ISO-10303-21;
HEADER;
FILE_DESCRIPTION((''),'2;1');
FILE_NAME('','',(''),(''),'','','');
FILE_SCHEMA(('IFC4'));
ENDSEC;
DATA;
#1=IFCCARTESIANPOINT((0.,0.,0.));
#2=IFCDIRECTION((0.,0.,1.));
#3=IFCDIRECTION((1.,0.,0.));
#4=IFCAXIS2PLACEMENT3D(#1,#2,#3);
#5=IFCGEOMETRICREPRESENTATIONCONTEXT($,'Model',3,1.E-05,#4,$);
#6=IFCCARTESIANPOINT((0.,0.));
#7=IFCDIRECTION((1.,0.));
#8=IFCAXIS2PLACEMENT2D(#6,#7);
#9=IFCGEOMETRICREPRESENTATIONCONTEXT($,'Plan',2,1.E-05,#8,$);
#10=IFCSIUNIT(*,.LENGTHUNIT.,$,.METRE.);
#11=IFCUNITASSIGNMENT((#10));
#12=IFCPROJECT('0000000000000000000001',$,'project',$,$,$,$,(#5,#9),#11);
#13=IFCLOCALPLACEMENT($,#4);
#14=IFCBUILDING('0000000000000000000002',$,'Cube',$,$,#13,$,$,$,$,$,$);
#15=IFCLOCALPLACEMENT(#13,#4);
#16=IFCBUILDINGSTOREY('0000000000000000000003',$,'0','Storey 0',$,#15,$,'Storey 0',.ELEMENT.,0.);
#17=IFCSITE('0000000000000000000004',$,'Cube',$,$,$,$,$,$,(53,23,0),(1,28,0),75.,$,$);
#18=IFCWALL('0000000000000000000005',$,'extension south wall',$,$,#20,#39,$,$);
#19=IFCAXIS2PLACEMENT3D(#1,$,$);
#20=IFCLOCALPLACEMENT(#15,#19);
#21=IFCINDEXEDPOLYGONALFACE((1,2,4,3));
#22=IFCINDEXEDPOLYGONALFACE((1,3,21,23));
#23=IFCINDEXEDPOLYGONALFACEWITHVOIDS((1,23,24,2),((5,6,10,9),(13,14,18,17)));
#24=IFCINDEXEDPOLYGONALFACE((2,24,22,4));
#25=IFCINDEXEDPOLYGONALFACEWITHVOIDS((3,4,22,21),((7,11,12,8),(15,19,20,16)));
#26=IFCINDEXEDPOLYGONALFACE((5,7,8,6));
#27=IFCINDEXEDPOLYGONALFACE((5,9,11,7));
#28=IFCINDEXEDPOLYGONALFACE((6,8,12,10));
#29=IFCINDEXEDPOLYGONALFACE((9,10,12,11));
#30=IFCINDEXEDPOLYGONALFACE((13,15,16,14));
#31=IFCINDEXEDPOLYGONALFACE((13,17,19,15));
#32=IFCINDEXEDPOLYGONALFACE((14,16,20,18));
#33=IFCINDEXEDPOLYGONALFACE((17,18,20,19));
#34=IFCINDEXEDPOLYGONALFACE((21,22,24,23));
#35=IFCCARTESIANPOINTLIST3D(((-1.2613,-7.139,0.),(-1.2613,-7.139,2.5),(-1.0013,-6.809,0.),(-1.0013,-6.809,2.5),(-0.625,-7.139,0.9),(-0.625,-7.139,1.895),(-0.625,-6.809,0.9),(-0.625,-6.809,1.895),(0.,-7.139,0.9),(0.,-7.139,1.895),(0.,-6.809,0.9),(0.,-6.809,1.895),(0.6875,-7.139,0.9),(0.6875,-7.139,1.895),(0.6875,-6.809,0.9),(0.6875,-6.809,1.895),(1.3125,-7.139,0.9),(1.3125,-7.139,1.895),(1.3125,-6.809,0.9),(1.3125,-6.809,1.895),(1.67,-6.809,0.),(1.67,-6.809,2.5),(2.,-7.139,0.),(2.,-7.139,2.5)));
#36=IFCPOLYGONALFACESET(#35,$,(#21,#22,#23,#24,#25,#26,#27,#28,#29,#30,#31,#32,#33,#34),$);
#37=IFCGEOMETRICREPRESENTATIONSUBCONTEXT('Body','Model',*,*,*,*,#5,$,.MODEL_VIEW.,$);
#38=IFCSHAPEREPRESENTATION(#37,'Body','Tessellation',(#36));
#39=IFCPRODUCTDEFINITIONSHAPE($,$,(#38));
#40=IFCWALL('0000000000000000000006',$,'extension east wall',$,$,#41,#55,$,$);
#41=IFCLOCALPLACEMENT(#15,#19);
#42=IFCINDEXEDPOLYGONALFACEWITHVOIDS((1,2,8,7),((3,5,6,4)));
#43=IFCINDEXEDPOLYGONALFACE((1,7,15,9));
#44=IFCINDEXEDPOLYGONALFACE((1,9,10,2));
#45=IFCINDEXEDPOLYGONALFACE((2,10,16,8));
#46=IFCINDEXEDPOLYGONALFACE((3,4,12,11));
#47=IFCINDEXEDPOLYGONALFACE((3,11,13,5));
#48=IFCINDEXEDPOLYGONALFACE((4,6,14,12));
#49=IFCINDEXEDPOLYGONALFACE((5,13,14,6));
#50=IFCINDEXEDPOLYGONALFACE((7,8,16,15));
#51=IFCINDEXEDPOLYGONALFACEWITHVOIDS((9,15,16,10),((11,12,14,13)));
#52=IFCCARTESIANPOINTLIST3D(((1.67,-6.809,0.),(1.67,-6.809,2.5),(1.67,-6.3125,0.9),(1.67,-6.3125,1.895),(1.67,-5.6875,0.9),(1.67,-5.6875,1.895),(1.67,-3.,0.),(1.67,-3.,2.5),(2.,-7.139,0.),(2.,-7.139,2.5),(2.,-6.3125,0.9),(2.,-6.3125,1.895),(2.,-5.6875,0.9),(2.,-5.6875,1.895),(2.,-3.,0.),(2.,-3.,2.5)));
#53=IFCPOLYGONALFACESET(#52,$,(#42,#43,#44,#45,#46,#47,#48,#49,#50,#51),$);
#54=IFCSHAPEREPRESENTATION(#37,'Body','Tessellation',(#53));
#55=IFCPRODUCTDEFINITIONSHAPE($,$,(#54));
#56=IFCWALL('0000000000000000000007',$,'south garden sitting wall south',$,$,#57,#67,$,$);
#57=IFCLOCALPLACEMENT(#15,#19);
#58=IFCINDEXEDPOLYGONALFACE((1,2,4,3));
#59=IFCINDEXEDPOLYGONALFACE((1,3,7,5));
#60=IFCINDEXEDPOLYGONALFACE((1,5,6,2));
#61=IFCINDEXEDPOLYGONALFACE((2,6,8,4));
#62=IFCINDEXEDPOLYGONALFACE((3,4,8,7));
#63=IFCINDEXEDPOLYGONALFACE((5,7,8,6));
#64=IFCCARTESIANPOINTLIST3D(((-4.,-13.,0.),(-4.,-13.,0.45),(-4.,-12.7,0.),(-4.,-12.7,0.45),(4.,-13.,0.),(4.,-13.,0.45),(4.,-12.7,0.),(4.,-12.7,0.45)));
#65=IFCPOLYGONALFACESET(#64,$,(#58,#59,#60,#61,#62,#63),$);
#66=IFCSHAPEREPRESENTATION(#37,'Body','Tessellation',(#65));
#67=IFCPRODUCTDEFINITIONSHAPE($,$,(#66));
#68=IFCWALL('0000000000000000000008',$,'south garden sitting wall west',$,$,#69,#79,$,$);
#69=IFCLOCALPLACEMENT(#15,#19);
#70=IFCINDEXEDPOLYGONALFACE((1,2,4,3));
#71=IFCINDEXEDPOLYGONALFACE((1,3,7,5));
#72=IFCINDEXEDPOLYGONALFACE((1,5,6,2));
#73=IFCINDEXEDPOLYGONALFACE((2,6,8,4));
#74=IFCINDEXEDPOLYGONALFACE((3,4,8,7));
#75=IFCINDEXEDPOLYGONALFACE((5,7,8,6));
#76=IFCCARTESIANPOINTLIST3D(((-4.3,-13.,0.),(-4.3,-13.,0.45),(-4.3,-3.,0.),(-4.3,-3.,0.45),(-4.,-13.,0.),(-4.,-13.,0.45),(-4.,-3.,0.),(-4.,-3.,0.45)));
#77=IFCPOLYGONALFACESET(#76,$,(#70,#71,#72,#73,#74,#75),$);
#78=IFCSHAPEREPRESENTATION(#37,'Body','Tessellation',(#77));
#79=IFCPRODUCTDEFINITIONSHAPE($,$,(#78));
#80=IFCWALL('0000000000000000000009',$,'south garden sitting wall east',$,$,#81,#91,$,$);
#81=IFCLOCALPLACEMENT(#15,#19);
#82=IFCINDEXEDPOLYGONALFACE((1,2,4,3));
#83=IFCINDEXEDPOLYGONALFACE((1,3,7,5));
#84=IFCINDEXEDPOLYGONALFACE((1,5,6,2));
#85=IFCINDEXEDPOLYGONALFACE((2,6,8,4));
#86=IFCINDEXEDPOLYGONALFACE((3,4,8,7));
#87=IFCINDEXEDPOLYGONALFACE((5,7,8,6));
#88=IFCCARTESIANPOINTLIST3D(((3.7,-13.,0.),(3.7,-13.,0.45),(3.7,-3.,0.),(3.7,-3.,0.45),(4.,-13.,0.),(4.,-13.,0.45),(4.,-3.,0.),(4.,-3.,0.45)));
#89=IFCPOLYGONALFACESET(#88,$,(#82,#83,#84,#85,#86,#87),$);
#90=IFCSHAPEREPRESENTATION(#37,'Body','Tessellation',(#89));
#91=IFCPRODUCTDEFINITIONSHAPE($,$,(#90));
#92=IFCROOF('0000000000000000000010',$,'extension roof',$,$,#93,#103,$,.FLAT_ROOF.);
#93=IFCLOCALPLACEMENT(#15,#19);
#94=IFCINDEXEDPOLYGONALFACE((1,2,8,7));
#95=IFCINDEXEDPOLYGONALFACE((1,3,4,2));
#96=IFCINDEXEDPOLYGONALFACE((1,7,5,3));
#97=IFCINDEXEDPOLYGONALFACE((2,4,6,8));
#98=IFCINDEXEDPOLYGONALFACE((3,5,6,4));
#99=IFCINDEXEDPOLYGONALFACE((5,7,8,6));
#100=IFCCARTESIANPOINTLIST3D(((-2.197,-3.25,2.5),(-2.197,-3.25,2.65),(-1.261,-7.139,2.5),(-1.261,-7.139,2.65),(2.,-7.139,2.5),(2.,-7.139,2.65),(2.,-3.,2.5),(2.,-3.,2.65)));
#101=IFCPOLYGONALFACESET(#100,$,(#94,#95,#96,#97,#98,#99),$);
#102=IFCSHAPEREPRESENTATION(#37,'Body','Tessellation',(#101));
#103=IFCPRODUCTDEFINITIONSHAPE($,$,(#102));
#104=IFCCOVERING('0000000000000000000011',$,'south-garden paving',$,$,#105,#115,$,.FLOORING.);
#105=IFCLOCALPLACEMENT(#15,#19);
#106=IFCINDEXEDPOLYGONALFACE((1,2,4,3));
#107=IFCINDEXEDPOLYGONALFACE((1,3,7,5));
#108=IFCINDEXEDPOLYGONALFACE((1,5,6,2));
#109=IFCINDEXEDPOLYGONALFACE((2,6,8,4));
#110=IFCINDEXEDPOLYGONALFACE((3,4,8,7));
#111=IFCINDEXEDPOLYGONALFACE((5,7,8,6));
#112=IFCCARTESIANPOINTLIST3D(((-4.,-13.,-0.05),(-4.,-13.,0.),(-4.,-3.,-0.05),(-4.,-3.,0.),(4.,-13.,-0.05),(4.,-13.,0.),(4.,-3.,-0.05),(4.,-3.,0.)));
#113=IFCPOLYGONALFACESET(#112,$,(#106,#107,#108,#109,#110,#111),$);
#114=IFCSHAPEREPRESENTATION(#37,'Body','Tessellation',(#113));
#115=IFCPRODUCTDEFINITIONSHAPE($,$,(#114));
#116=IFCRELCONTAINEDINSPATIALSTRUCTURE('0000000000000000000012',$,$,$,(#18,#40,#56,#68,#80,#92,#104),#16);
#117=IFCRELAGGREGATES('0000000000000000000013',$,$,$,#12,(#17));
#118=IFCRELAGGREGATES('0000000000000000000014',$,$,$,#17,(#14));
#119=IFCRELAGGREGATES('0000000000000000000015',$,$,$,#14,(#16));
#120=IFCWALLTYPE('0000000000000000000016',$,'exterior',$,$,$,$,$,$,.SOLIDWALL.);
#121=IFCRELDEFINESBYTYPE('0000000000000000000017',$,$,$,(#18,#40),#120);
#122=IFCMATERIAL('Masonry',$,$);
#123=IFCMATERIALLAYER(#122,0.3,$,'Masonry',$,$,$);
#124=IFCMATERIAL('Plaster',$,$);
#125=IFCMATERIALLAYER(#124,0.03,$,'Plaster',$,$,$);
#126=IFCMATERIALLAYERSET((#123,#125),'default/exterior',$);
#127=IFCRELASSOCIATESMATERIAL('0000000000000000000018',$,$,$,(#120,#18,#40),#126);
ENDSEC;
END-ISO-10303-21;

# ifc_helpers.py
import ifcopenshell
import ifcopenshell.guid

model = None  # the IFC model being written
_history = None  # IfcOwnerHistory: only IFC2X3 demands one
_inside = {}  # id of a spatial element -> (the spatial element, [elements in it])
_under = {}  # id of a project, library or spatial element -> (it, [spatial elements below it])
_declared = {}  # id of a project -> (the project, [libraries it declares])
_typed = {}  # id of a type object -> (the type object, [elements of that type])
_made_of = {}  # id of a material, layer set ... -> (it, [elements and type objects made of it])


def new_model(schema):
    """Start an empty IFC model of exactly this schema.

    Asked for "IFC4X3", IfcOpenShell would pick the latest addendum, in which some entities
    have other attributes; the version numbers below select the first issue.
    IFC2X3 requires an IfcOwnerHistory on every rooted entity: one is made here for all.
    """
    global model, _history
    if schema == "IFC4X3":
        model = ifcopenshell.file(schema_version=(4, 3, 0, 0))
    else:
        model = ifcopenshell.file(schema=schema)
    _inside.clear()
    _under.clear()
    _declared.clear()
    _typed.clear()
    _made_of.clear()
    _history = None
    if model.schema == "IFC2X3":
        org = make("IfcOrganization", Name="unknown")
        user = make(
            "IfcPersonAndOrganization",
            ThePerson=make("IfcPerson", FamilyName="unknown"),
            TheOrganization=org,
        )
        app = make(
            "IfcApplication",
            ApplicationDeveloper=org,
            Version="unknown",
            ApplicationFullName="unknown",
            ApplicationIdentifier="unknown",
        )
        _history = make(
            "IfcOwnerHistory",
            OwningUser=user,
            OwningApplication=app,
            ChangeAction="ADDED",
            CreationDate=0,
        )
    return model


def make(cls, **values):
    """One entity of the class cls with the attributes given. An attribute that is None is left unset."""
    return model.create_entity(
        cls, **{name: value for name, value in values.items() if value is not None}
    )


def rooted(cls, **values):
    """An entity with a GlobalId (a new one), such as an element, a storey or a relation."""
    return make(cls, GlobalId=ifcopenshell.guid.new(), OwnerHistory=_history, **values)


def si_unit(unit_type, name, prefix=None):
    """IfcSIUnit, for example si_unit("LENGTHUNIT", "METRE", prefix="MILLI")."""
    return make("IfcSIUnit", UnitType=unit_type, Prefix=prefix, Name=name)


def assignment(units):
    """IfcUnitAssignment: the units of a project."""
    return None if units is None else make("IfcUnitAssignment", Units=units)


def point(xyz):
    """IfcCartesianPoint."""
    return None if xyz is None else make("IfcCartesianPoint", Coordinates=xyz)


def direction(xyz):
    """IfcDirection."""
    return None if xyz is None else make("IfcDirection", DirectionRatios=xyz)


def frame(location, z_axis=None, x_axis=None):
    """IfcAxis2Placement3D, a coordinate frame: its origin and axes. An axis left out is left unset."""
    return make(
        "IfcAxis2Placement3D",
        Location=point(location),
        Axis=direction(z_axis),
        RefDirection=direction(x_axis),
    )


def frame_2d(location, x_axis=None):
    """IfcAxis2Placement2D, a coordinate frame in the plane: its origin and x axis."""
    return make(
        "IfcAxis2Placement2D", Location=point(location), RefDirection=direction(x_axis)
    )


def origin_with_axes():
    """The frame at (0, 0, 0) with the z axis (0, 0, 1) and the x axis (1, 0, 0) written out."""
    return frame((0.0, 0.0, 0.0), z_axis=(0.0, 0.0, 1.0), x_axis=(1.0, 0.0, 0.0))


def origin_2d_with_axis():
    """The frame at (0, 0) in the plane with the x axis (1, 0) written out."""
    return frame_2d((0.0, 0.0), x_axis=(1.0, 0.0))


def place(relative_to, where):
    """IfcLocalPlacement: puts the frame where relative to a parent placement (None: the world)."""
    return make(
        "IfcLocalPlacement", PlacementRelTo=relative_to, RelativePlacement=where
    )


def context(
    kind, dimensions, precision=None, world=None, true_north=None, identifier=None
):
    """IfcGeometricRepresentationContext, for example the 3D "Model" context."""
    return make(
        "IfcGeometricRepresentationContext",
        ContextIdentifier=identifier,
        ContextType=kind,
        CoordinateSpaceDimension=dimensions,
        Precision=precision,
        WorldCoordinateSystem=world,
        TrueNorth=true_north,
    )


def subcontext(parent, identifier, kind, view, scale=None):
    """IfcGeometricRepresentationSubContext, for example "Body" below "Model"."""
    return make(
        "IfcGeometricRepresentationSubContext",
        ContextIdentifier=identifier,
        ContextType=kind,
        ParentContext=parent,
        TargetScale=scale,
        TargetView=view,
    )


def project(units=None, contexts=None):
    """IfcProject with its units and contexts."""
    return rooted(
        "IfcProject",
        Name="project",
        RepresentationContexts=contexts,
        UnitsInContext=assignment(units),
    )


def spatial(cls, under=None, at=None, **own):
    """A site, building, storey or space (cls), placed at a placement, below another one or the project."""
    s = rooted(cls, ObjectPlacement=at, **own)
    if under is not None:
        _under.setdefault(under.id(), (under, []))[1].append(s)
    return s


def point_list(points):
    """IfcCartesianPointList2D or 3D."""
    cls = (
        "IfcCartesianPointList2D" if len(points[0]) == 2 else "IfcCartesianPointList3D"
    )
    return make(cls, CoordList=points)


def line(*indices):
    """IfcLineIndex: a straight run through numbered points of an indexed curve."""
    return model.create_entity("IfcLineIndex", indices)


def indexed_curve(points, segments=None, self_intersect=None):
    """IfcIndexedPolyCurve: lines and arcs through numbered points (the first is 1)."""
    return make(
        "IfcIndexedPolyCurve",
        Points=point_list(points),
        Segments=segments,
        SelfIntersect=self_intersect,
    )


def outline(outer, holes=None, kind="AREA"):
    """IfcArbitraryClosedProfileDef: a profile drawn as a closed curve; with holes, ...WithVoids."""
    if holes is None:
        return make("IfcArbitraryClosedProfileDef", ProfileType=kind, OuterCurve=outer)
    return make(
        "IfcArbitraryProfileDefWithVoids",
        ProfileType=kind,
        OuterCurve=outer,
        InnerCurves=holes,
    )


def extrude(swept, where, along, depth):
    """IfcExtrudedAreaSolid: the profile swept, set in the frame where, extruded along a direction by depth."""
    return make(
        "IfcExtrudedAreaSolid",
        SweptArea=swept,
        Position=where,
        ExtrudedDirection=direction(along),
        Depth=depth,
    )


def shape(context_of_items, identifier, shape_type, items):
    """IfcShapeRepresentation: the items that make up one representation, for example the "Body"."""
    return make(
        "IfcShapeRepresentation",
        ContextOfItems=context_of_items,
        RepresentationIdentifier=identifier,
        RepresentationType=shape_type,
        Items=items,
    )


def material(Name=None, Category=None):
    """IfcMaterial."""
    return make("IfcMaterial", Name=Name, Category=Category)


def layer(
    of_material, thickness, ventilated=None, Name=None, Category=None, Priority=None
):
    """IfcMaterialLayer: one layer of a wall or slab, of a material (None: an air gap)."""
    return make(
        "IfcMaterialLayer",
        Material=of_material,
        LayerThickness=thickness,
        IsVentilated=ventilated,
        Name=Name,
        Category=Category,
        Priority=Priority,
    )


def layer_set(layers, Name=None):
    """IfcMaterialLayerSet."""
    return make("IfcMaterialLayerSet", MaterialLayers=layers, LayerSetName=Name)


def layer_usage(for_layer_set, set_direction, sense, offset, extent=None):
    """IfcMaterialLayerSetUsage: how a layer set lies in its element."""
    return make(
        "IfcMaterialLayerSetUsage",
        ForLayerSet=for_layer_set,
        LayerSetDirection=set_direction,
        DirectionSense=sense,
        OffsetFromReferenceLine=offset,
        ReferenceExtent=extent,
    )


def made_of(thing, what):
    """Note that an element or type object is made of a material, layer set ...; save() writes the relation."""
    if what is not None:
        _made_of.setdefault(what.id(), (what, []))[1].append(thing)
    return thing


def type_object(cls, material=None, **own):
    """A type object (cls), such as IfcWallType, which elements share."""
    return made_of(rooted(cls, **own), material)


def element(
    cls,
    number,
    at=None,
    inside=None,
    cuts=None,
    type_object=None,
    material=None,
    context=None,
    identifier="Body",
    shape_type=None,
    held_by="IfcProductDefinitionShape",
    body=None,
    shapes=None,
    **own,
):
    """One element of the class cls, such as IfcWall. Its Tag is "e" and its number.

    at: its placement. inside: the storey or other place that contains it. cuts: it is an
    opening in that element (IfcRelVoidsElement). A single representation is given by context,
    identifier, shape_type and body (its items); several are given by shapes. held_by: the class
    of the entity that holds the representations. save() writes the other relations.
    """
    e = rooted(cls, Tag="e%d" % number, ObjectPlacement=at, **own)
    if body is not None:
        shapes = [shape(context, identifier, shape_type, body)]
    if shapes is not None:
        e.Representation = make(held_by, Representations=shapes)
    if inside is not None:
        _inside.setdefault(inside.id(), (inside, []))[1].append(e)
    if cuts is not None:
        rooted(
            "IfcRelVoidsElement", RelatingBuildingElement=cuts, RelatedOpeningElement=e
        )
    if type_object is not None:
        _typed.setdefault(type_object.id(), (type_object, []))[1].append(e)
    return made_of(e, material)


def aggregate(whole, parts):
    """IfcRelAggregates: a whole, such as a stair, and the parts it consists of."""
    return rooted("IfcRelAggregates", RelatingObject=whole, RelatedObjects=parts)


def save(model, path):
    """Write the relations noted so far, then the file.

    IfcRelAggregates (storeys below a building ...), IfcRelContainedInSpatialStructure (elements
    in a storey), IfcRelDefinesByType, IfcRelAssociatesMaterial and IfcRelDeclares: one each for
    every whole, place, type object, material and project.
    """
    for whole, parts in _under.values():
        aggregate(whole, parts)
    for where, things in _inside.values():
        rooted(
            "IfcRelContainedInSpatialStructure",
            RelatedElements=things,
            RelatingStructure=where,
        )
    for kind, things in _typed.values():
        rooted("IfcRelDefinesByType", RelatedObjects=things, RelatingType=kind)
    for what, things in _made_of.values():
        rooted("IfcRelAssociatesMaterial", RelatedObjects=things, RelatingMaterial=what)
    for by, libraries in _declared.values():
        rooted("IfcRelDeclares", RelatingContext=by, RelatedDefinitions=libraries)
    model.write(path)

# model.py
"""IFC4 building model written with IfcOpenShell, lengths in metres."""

from ifc_helpers import new_model, si_unit, frame, origin_with_axes, origin_2d_with_axis, place, context, subcontext, project, spatial, line, indexed_curve, outline, extrude, material, layer, layer_set, layer_usage, type_object, element, save


model = new_model("IFC4")

# Units and contexts
model_context = context("Model", 3, precision=1e-05, world=origin_with_axes())
plan_context = context("Plan", 2, precision=1e-05, world=origin_2d_with_axis())
body_context_1 = subcontext(model_context, "Body", "Model", "MODEL_VIEW")
ifc_project = project(units=[si_unit("LENGTHUNIT", "METRE")], contexts=[model_context, plan_context])

# Site, building, storey
site = spatial("IfcSite", under=ifc_project, Name="Cube", RefLatitude=(53, 23, 0), RefLongitude=(1, 28, 0), RefElevation=75.0)
building_placement = place(None, origin_with_axes())
building = spatial("IfcBuilding", under=site, at=building_placement, Name="Cube")
storey_placement = place(building_placement, origin_with_axes())
storey = spatial("IfcBuildingStorey", under=building, at=storey_placement, Name="0", Description="Storey 0", LongName="Storey 0", CompositionType="ELEMENT", Elevation=0.0)

# Wall, openings
ifc_material_1 = material(Name="Masonry")
ifc_layer_1 = layer(ifc_material_1, 0.3, Name="Masonry")
ifc_material_2 = material(Name="Plaster")
ifc_layer_2 = layer(ifc_material_2, 0.03, Name="Plaster")
ifc_layer_set = layer_set([ifc_layer_1, ifc_layer_2], Name="default/exterior")
ifc_layer_usage = layer_usage(ifc_layer_set, "AXIS2", "POSITIVE", 0.0)
wall_type = type_object("IfcWallType", Name="exterior", PredefinedType="SOLIDWALL", material=ifc_layer_set)
wall_1_placement = place(storey_placement, frame((-1.2613, -7.139, 0.0), z_axis=(0.0, 0.0, 1.0), x_axis=(1.0, 0.0, 0.0)))
wall_1 = element("IfcWall", 1, at=wall_1_placement, inside=storey, type_object=wall_type, material=ifc_layer_usage, Name="extension south wall", context=body_context_1, shape_type="SweptSolid", body=[
    extrude(outline(indexed_curve([(0.0, 0.0), (0.26, 0.33), (2.9313, 0.33), (3.2613, 0.0)], segments=[line(1, 2, 3, 4, 1)])), origin_with_axes(), (0.0, 0.0, 1.0), 2.5),
])
opening_1_placement = place(wall_1_placement, frame((0.6363, 0.0, 0.9), z_axis=(0.0, 0.0, 1.0), x_axis=(1.0, 0.0, 0.0)))
element("IfcOpeningElement", 2, at=opening_1_placement, cuts=wall_1, PredefinedType="OPENING", context=body_context_1, shape_type="SweptSolid", body=[
    extrude(outline(indexed_curve([(0.0, 0.0), (0.0, 0.5), (0.625, 0.5), (0.625, 0.0), (0.0, 0.0)], self_intersect=False)), origin_with_axes(), (0.0, 0.0, 1.0), 0.995),
])
opening_2_placement = place(wall_1_placement, frame((1.9488, 0.0, 0.9), z_axis=(0.0, 0.0, 1.0), x_axis=(1.0, 0.0, 0.0)))
element("IfcOpeningElement", 3, at=opening_2_placement, cuts=wall_1, PredefinedType="OPENING", context=body_context_1, shape_type="SweptSolid", body=[
    extrude(outline(indexed_curve([(0.0, 0.0), (0.0, 0.5), (0.625, 0.5), (0.625, 0.0), (0.0, 0.0)], self_intersect=False)), origin_with_axes(), (0.0, 0.0, 1.0), 0.995),
])

# Wall, opening
wall_2_placement = place(storey_placement, frame((2.0, -7.139, 0.0), z_axis=(0.0, 0.0, 1.0), x_axis=(0.0, 1.0, 0.0)))
wall_2 = element("IfcWall", 4, at=wall_2_placement, inside=storey, type_object=wall_type, material=ifc_layer_usage, Name="extension east wall", context=body_context_1, shape_type="SweptSolid", body=[
    extrude(outline(indexed_curve([(0.0, 0.0), (0.33, 0.33), (4.139, 0.33), (4.139, 0.0)], segments=[line(1, 2, 3, 4, 1)])), origin_with_axes(), (0.0, 0.0, 1.0), 2.5),
])
opening_3_placement = place(wall_2_placement, frame((0.8265, 0.0, 0.9), z_axis=(0.0, 0.0, 1.0), x_axis=(1.0, 0.0, 0.0)))
element("IfcOpeningElement", 5, at=opening_3_placement, cuts=wall_2, PredefinedType="OPENING", context=body_context_1, shape_type="SweptSolid", body=[
    extrude(outline(indexed_curve([(0.0, 0.0), (0.0, 0.5), (0.625, 0.5), (0.625, 0.0), (0.0, 0.0)], self_intersect=False)), origin_with_axes(), (0.0, 0.0, 1.0), 0.995),
])

# Walls
wall_3_placement = place(storey_placement, frame((-4.0, -13.0, 0.0), z_axis=(0.0, 0.0, 1.0), x_axis=(1.0, 0.0, 0.0)))
element("IfcWall", 6, at=wall_3_placement, inside=storey, Name="south garden sitting wall south", context=body_context_1, shape_type="SweptSolid", body=[
    extrude(outline(indexed_curve([(0.0, 0.0), (0.0, 0.3), (8.0, 0.3), (8.0, 0.0), (0.0, 0.0)], self_intersect=False)), origin_with_axes(), (0.0, 0.0, 1.0), 0.45),
])
for number, where, z_axis, x_axis, name in (
    (7, (-4.0, -13.0, 0.0), (0.0, 0.0, 1.0), (0.0, 1.0, 0.0), "south garden sitting wall west"),
    (8, (4.0, -13.0, 0.0), (0.0, 0.0, 1.0), (0.0, 1.0, 0.0), "south garden sitting wall east"),
):
    element("IfcWall", number, at=place(storey_placement, frame(where, z_axis=z_axis, x_axis=x_axis)), inside=storey, Name=name, context=body_context_1, shape_type="SweptSolid", body=[
        extrude(outline(indexed_curve([(0.0, 0.0), (0.0, 0.3), (10.0, 0.3), (10.0, 0.0), (0.0, 0.0)], self_intersect=False)), origin_with_axes(), (0.0, 0.0, 1.0), 0.45),
    ])

# Roof
roof_placement = place(storey_placement, frame((-1.261, -7.139, 2.5), z_axis=(0.0, 0.0, 1.0), x_axis=(1.0, 0.0, 0.0)))
element("IfcRoof", 9, at=roof_placement, inside=storey, Name="extension roof", PredefinedType="FLAT_ROOF", context=body_context_1, shape_type="SweptSolid", body=[
    extrude(outline(indexed_curve([(0.0, 0.0), (3.261, 0.0), (3.261, 4.139), (-0.936, 3.889)])), None, (0.0, 0.0, 1.0), 0.15),
])

# Covering
covering_placement = place(storey_placement, frame((-4.0, -13.0, 0.0), z_axis=(0.0, 0.0, 1.0), x_axis=(1.0, 0.0, 0.0)))
element("IfcCovering", 10, at=covering_placement, inside=storey, Name="south-garden paving", PredefinedType="FLOORING", context=body_context_1, shape_type="SweptSolid", body=[
    extrude(outline(indexed_curve([(0.0, 0.0), (8.0, 0.0), (8.0, 10.0), (0.0, 10.0)])), None, (0.0, 0.0, -1.0), 0.05),
])

save(model, "model.ifc")
